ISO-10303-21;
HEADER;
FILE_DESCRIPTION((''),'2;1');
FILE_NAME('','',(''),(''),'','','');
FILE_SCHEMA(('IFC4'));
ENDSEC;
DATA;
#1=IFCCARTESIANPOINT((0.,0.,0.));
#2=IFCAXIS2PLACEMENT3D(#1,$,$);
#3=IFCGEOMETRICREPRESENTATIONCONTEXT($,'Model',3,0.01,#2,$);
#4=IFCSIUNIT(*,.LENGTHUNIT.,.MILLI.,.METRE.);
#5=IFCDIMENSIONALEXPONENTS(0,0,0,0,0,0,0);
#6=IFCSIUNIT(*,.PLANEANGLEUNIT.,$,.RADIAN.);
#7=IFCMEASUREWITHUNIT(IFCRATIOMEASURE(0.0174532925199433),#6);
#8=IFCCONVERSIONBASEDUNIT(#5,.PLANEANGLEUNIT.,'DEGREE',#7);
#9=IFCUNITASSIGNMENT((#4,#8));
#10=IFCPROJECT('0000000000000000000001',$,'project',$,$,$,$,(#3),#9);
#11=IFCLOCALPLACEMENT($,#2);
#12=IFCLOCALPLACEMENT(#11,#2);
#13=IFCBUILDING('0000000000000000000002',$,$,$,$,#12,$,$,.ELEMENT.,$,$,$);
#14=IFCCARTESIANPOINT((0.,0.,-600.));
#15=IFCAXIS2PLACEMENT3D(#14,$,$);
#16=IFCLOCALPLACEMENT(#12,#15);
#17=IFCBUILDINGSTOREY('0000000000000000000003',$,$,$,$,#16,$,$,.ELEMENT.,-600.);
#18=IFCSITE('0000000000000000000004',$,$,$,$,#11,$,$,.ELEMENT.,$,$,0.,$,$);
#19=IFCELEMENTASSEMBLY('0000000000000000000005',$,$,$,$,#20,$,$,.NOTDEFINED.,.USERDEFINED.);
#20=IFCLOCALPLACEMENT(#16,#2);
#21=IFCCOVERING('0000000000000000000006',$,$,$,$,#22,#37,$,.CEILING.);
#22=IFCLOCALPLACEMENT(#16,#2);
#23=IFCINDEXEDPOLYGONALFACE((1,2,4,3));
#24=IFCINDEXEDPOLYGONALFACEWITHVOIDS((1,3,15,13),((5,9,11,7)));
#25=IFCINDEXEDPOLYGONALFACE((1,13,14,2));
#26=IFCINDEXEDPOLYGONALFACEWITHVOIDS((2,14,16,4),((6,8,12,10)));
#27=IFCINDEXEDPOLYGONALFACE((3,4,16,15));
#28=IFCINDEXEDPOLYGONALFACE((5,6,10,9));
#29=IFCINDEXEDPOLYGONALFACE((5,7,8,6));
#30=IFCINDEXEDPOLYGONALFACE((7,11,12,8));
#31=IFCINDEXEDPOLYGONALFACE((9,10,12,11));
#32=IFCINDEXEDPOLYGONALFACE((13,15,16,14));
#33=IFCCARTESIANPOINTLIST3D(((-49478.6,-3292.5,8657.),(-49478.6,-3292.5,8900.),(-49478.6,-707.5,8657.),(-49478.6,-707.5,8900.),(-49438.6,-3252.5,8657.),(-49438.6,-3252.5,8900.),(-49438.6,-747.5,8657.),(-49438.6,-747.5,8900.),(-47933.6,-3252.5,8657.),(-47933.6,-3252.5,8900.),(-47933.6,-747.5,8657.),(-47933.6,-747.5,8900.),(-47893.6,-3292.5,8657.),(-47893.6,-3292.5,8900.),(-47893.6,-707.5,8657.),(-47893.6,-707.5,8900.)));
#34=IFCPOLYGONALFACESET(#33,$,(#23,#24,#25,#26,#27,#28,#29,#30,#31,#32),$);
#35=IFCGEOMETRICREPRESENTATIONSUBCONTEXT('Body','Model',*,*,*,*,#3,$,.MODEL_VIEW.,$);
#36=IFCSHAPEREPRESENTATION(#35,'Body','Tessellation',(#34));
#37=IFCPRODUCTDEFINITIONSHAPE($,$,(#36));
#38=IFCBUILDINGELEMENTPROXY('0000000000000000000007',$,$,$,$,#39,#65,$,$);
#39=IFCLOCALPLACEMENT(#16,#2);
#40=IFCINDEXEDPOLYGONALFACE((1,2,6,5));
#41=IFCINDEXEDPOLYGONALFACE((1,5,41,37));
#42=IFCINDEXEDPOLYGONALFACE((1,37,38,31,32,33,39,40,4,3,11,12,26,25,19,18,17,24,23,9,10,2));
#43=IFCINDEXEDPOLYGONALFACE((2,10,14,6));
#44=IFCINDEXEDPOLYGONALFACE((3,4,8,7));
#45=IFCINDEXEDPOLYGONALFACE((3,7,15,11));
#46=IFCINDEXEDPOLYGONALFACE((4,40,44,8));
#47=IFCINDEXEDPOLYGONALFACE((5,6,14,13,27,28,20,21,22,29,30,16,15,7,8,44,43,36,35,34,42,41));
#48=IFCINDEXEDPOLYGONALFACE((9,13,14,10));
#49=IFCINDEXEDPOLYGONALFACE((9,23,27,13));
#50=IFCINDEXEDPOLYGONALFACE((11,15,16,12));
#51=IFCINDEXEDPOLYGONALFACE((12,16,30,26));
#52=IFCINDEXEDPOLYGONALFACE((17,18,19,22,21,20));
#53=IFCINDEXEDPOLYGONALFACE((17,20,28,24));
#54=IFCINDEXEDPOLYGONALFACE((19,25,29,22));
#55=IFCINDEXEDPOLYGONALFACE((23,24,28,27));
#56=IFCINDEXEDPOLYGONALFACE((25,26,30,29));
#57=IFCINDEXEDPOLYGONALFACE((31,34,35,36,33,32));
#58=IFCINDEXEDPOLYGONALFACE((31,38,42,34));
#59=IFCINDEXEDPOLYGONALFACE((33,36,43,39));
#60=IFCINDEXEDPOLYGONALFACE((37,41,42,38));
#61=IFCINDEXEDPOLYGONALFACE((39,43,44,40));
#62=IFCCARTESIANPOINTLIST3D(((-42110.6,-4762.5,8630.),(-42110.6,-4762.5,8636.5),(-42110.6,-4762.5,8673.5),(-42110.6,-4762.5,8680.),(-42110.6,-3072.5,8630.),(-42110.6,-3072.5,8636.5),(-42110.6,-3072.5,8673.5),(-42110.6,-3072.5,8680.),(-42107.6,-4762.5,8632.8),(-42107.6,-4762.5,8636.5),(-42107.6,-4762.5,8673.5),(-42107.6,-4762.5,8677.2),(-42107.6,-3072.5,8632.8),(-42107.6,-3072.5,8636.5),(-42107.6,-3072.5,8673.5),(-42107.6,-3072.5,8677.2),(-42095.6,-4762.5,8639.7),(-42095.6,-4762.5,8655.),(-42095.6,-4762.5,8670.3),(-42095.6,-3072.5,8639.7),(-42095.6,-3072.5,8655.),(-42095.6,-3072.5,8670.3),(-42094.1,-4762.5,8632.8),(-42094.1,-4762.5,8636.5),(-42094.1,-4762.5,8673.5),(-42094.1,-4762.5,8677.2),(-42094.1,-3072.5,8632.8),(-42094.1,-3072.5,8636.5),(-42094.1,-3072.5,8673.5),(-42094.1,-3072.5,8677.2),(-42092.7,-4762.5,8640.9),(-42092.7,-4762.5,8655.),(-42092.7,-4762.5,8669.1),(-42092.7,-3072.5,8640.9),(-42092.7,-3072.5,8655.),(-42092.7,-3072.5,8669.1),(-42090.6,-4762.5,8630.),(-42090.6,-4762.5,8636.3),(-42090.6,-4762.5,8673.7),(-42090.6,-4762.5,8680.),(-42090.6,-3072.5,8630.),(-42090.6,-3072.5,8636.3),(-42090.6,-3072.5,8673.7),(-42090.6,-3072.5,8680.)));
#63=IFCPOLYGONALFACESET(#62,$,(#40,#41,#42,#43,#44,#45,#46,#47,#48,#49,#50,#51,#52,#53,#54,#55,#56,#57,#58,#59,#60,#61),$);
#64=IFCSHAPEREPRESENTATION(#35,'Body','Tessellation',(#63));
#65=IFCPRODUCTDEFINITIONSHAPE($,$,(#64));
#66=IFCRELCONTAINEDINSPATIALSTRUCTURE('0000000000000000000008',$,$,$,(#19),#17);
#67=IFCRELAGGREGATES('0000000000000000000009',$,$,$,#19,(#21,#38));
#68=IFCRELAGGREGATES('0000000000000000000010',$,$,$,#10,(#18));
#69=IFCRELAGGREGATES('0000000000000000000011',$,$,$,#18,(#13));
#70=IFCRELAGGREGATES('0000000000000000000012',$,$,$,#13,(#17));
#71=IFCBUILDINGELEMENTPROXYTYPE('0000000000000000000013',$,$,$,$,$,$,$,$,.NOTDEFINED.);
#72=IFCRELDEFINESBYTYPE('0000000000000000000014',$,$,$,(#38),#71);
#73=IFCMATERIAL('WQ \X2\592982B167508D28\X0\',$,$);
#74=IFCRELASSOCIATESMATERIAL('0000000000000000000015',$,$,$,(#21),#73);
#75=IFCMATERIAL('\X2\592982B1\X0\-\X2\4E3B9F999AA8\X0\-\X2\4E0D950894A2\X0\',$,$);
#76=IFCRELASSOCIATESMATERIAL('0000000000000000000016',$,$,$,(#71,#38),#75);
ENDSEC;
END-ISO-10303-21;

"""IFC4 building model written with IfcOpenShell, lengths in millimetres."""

from ifc_helpers import new_model, entity, si_unit, converted_unit, frame, origin, place, context, subcontext, project, spatial, polyline, outline, extrude, source, transform, mapped, material, type_object, type_shapes, element, aggregate, save


model = new_model("IFC4")

# Units and contexts
model_context = context("Model", 3, precision=0.01, world=origin())
body_context = subcontext(model_context, "Body", "Model", "MODEL_VIEW")
ifc_project = project(units=[si_unit("LENGTHUNIT", "METRE", prefix="MILLI"), converted_unit("PLANEANGLEUNIT", "DEGREE", entity("IfcRatioMeasure", 0.0174532925199433), si_unit("PLANEANGLEUNIT", "RADIAN"), dimensions=[0, 0, 0, 0, 0, 0, 0])], contexts=[model_context])

# Site, building, storey
site_placement = place(None, origin())
site = spatial("IfcSite", under=ifc_project, at=site_placement, CompositionType="ELEMENT", RefElevation=0.0)
building_placement = place(site_placement, origin())
building = spatial("IfcBuilding", under=site, at=building_placement, CompositionType="ELEMENT")
storey_placement = place(building_placement, frame((0.0, 0.0, -600.0)))
storey = spatial("IfcBuildingStorey", under=building, at=storey_placement, CompositionType="ELEMENT", Elevation=-600.0)

# Element assembly, covering, building element proxy
assembly_placement = place(storey_placement, origin())
assembly = element("IfcElementAssembly", 1, at=assembly_placement, inside=storey, AssemblyPlace="NOTDEFINED", PredefinedType="USERDEFINED")
ifc_material_1 = material(Name="WQ 天花材质")
covering_1_placement = place(assembly_placement, frame((-49478.6, -3292.5, 8657.0)))
covering_1 = element("IfcCovering", 2, at=covering_1_placement, material=ifc_material_1, PredefinedType="CEILING", context=body_context, shape_type="SweptSolid", body=[
    extrude(outline(polyline([(-1292.5, -792.5), (1292.5, -792.5), (1292.5, 792.5), (-1292.5, 792.5), (-1292.5, -792.5)]), holes=[polyline([(-1252.5, -752.5), (-1252.5, 752.5), (1252.5, 752.5), (1252.5, -752.5), (-1252.5, -752.5)])]), frame((792.5, 1292.5, 0.0), z_axis=(0.0, 0.0, 1.0), x_axis=(0.0, 1.0, 0.0)), (0.0, 0.0, 1.0), 243.0),
])
ifc_material_2 = material(Name="天花-主龙骨-不锈钢")
building_element_proxy_type_1 = type_object("IfcBuildingElementProxyType", PredefinedType="NOTDEFINED", material=ifc_material_2)
shared_shape_1 = source(origin(), body_context, "Body", "SweptSolid", [
    extrude(outline(polyline([(-25.0, -11.7), (-18.5, -11.7), (-18.5, -8.7), (-22.2, -8.7), (-22.2, 4.8), (-18.5, 4.8), (-15.3, 3.3), (0.0, 3.3), (15.3, 3.3), (18.5, 4.8), (22.2, 4.8), (22.2, -8.7), (18.5, -8.7), (18.5, -11.7), (25.0, -11.7), (25.0, 8.3), (18.7, 8.3), (14.1, 6.2), (0.0, 6.2), (-14.1, 6.2), (-18.7, 8.3), (-25.0, 8.3), (-25.0, -11.7)])), frame((0.0, 1.7, 0.0), z_axis=(1.0, 0.0, 0.0), x_axis=(0.0, 0.0, -1.0)), (0.0, 0.0, 1.0), 1690.0),
])
type_shapes(building_element_proxy_type_1, [shared_shape_1])
proxy_1_placement = place(assembly_placement, frame((-42100.6, -3072.5, 8655.0), z_axis=(0.0, 0.0, 1.0), x_axis=(0.0, -1.0, 0.0)))
proxy_1 = element("IfcBuildingElementProxy", 3, at=proxy_1_placement, type_object=building_element_proxy_type_1, material=ifc_material_2, context=body_context, shape_type="MappedRepresentation", body=[
    mapped(shared_shape_1, transform((0.0, 0.0, 0.0), scale=1.0)),
])
aggregate(assembly, [covering_1, proxy_1])

save(model, "model.ifc")
